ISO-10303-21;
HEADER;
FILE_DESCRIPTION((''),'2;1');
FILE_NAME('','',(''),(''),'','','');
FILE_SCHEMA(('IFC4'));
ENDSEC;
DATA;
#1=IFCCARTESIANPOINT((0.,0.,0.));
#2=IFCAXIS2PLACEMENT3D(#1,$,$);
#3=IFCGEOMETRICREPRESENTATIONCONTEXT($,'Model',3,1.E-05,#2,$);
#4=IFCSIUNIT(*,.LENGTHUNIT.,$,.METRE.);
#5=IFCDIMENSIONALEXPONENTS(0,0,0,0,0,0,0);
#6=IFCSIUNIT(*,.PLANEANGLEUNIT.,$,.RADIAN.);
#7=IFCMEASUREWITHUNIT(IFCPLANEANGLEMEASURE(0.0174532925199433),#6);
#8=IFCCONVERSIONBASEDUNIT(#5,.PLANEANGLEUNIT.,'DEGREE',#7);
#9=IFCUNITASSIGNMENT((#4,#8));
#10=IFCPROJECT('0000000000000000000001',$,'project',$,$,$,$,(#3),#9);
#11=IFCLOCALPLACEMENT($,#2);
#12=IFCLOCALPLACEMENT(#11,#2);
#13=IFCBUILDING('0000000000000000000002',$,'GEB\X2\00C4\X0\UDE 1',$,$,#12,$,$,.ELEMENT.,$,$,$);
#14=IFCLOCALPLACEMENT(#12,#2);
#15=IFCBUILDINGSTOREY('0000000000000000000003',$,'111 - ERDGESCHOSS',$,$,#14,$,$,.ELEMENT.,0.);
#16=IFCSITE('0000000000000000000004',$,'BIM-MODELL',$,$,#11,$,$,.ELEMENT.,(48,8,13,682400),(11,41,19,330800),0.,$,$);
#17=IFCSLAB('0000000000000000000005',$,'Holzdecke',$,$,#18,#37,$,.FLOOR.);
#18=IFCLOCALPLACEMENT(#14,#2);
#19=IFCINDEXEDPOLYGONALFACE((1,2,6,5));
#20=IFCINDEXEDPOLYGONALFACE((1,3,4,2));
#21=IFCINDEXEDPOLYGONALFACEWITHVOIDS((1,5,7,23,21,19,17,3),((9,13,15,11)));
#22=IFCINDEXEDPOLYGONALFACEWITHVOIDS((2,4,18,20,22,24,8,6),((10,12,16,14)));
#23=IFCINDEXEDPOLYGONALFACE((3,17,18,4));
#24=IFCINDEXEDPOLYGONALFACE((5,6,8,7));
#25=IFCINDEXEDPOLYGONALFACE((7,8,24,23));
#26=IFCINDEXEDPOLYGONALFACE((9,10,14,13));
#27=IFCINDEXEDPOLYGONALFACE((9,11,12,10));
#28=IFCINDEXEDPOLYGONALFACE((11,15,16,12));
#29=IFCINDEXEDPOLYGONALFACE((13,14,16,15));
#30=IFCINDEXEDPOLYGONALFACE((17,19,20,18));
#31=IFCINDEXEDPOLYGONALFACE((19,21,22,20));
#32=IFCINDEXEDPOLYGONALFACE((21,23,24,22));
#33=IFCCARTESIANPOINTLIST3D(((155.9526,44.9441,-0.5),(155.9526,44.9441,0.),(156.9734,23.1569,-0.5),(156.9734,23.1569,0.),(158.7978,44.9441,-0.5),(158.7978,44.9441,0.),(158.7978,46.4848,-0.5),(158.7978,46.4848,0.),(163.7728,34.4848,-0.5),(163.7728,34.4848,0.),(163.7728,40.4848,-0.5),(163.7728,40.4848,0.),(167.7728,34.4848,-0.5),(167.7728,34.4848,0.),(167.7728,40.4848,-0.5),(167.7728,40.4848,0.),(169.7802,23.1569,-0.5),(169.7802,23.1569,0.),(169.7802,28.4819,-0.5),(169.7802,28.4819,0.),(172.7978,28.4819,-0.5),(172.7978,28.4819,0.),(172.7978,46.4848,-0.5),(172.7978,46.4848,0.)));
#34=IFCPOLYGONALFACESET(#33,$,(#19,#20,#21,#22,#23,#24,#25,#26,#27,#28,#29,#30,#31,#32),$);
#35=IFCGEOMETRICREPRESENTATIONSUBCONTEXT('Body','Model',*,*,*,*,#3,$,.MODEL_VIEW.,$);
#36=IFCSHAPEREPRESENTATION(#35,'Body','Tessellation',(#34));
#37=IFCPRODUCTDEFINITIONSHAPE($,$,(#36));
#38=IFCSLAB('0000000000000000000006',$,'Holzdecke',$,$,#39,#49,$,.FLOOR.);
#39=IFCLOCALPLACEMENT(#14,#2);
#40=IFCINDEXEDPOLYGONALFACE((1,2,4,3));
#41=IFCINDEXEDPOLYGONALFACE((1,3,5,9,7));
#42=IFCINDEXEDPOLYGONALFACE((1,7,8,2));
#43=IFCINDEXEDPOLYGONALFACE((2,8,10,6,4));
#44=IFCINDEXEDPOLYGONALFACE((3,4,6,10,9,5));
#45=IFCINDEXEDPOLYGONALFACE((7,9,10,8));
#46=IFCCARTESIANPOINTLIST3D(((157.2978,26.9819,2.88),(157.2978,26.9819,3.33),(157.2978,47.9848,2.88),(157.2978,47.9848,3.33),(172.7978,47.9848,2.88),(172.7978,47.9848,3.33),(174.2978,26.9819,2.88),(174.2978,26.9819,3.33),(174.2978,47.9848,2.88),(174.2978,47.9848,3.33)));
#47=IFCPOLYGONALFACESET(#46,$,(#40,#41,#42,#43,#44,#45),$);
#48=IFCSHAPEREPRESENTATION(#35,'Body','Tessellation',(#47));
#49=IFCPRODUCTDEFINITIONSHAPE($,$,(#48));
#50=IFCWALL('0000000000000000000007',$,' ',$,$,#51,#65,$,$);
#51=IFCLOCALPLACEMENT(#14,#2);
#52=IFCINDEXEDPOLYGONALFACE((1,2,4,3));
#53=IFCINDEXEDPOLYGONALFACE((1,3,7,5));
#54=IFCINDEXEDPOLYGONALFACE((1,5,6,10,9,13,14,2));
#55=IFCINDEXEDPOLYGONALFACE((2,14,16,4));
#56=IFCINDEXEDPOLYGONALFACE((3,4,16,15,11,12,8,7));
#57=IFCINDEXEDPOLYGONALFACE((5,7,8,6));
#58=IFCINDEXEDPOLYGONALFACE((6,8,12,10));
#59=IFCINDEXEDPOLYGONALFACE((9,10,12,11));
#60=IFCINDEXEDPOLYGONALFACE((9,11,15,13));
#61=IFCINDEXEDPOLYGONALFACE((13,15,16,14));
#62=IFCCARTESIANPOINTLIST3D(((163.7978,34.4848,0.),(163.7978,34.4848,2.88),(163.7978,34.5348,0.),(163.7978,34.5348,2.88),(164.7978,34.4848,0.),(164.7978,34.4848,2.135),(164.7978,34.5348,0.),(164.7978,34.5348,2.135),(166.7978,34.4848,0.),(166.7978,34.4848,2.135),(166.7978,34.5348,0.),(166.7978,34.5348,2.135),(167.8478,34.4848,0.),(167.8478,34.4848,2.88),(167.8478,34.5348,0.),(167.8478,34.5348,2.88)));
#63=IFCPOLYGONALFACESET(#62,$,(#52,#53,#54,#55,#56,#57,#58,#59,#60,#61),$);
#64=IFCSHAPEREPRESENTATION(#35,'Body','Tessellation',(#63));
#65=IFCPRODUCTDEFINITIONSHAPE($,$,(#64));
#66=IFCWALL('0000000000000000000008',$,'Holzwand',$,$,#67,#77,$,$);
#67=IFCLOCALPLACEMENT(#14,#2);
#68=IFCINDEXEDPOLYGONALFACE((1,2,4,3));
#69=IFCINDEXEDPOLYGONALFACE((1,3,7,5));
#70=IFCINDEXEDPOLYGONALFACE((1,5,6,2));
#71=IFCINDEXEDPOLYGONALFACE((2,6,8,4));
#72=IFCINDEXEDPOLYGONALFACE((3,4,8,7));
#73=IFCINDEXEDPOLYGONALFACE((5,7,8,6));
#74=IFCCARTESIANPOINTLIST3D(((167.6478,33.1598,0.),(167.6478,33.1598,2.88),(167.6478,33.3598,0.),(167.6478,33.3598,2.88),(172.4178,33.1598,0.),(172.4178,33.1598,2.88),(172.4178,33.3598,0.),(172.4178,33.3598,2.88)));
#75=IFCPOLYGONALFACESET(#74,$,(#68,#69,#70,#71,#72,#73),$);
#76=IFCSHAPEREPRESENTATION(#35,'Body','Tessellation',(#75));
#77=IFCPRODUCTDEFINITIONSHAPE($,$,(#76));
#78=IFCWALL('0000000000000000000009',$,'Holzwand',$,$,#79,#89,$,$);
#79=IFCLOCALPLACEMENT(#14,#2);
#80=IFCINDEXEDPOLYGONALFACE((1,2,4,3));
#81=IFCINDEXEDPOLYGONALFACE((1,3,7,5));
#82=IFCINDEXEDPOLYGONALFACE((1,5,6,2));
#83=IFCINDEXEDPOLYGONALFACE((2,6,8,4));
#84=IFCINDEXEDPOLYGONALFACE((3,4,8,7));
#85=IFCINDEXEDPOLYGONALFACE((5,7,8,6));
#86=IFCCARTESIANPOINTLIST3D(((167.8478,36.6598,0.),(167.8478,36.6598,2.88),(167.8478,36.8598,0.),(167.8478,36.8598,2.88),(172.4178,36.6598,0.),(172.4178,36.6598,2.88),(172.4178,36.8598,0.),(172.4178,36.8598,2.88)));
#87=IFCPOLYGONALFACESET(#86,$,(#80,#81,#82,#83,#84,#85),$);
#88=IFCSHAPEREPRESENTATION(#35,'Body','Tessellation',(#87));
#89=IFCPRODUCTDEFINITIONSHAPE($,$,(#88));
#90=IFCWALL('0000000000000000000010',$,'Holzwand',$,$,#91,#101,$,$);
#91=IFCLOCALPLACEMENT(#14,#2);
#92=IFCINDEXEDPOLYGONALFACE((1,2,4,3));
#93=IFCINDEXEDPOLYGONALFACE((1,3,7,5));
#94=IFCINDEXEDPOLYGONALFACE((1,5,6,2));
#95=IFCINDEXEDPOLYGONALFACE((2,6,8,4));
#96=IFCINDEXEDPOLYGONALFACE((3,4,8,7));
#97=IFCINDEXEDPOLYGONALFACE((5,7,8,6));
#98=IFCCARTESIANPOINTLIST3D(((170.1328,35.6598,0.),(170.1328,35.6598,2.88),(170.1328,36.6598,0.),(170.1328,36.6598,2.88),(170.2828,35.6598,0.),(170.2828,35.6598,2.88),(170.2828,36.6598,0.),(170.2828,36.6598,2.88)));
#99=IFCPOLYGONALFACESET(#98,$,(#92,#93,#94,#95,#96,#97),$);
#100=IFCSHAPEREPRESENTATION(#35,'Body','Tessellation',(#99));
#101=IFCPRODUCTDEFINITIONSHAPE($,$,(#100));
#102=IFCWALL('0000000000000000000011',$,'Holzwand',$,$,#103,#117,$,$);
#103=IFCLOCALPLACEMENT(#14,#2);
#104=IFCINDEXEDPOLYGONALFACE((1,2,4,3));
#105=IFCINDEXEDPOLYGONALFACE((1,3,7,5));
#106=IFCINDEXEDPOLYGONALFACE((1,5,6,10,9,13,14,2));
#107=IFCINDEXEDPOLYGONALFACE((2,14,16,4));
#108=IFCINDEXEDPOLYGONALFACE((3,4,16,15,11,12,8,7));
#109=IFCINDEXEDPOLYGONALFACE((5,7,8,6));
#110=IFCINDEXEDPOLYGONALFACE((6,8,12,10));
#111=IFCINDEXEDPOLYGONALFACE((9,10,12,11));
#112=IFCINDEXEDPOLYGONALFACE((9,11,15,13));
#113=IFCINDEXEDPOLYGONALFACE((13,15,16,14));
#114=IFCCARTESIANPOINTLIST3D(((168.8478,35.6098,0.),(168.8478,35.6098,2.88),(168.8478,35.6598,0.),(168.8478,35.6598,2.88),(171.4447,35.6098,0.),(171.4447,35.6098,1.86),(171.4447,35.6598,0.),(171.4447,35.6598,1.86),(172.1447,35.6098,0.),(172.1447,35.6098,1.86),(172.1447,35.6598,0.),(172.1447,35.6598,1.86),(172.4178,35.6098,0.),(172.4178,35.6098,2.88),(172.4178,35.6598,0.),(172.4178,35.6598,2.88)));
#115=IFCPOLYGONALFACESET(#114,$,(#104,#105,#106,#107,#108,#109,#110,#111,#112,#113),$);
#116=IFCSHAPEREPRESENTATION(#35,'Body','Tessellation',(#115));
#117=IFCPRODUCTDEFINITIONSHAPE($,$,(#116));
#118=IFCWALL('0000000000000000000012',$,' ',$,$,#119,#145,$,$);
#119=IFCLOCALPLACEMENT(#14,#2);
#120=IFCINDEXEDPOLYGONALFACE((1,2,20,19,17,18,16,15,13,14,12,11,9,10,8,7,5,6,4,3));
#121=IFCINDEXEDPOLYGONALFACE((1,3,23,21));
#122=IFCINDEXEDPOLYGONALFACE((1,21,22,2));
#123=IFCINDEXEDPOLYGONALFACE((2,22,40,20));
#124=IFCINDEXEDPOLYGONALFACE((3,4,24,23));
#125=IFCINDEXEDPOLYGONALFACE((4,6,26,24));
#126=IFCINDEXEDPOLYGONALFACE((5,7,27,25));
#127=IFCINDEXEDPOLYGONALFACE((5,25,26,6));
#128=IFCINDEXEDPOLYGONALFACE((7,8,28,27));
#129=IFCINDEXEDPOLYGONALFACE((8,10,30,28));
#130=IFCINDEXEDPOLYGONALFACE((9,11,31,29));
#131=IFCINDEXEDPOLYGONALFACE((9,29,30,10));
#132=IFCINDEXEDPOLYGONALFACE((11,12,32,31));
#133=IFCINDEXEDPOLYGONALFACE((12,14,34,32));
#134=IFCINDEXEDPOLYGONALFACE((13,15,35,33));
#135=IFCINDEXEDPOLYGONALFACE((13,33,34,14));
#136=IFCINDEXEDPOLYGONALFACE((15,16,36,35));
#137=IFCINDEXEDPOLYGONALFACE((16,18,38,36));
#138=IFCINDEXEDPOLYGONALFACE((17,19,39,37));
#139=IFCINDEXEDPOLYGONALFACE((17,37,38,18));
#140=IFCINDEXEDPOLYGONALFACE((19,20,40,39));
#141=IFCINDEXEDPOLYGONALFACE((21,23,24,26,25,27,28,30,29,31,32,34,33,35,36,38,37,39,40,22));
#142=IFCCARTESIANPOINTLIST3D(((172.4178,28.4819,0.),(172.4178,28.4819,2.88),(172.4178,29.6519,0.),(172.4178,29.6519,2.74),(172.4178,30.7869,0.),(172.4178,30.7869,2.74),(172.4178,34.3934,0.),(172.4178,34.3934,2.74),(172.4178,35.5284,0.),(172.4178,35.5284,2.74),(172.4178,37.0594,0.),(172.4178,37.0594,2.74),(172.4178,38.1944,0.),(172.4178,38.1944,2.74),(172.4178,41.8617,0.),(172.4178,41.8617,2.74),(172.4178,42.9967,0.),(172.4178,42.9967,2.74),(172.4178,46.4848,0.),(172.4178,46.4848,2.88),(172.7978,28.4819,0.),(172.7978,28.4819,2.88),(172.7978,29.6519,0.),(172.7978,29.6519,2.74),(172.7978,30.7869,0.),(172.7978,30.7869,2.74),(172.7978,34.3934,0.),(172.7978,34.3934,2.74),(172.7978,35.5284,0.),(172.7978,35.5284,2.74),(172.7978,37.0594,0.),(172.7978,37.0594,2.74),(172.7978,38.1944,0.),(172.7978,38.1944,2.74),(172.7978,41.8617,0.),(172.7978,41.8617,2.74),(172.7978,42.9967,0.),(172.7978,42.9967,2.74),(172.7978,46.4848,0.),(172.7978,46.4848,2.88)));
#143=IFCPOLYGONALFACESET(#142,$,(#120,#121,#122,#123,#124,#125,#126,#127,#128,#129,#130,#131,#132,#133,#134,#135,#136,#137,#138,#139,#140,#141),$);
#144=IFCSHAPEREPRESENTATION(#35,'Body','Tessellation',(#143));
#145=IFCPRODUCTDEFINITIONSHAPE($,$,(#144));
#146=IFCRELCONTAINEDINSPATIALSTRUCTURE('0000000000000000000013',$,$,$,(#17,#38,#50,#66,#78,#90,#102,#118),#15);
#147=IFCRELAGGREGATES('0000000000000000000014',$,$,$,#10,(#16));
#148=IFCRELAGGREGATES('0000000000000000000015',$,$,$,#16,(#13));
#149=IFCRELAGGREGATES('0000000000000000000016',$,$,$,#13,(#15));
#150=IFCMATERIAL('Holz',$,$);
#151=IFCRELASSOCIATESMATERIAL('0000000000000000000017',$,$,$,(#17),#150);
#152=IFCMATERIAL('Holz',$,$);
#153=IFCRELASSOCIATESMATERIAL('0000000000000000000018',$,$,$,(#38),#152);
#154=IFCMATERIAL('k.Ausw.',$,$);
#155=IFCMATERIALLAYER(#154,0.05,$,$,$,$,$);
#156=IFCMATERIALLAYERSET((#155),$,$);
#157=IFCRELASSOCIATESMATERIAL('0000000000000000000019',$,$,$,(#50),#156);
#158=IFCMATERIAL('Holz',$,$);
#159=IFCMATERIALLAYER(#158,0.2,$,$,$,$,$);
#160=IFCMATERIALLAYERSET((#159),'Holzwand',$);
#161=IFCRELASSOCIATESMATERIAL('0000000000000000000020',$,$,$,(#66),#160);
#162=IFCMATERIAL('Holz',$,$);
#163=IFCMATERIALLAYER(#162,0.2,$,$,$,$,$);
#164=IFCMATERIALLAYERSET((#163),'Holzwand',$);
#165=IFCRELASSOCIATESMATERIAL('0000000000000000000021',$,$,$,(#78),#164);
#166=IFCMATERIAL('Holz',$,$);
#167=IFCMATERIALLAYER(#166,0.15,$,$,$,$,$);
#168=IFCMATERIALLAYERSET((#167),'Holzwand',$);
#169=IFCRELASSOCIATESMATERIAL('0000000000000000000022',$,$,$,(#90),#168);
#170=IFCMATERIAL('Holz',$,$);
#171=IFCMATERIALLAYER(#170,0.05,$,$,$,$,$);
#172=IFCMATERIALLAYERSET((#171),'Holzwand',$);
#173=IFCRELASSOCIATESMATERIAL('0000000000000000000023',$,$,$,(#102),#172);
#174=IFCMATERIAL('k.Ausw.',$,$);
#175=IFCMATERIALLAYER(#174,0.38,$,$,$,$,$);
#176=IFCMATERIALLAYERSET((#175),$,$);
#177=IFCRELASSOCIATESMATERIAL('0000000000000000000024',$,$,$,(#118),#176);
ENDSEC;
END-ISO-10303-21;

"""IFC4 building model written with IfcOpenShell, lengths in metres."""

from ifc_helpers import new_model, entity, si_unit, converted_unit, frame, frame_2d, origin, origin_with_axes, place, context, subcontext, project, spatial, polyline, rectangle, outline, extrude, material, layer, layer_set, layer_usage, element, save


model = new_model("IFC4")

# Units and contexts
model_context = context("Model", 3, precision=1e-05, world=origin())
body_context = subcontext(model_context, "Body", "Model", "MODEL_VIEW")
ifc_project = project(units=[si_unit("LENGTHUNIT", "METRE"), converted_unit("PLANEANGLEUNIT", "DEGREE", entity("IfcPlaneAngleMeasure", 0.0174532925199433), si_unit("PLANEANGLEUNIT", "RADIAN"), dimensions=[0, 0, 0, 0, 0, 0, 0])], contexts=[model_context])

# Site, building, storey
site_placement = place(None, origin())
site = spatial("IfcSite", under=ifc_project, at=site_placement, Name="BIM-MODELL", CompositionType="ELEMENT", RefLatitude=(48, 8, 13, 682400), RefLongitude=(11, 41, 19, 330800), RefElevation=0.0)
building_placement = place(site_placement, origin())
building = spatial("IfcBuilding", under=site, at=building_placement, Name="GEBÄUDE 1", CompositionType="ELEMENT")
storey_placement = place(building_placement, origin())
storey = spatial("IfcBuildingStorey", under=building, at=storey_placement, Name="111 - ERDGESCHOSS", CompositionType="ELEMENT", Elevation=0.0)

# Slabs
ifc_material_1 = material(Name="Holz")
slab_1_placement = place(storey_placement, frame((155.9526, 23.1569, -0.5)))
element("IfcSlab", 1, at=slab_1_placement, inside=storey, material=ifc_material_1, Name="Holzdecke", PredefinedType="FLOOR", context=body_context, shape_type="SweptSolid", body=[
    extrude(outline(polyline([(0.0, 21.7872), (1.0208, 0.0), (13.8276, 0.0), (13.8276, 5.3251), (16.8452, 5.3251), (16.8452, 23.3279), (2.8452, 23.3279), (2.8452, 21.7872), (0.0, 21.7872)]), holes=[polyline([(7.8202, 17.3279), (11.8202, 17.3279), (11.8202, 11.3279), (7.8202, 11.3279), (7.8202, 17.3279)])]), origin_with_axes(), (0.0, 0.0, 1.0), 0.5),
])
ifc_material_2 = material(Name="Holz")
slab_2_placement = place(storey_placement, frame((157.2978, 26.9819, 2.88)))
element("IfcSlab", 2, at=slab_2_placement, inside=storey, material=ifc_material_2, Name="Holzdecke", PredefinedType="FLOOR", context=body_context, shape_type="SweptSolid", body=[
    extrude(outline(polyline([(17.0, 0.0), (17.0, 21.0029), (15.5, 21.0029), (0.0, 21.0029), (0.0, 0.0), (17.0, 0.0)])), origin_with_axes(), (0.0, 0.0, 1.0), 0.45),
])

# Wall, opening
ifc_material_3 = material(Name="k.Ausw.")
ifc_layer_1 = layer(ifc_material_3, 0.05)
ifc_layer_set_1 = layer_set([ifc_layer_1])
ifc_layer_usage_1 = layer_usage(ifc_layer_set_1, "AXIS2", "POSITIVE", 0.0)
wall_1_placement = place(storey_placement, frame((163.7978, 34.4848, 0.0), z_axis=(0.0, 0.0, 1.0), x_axis=(1.0, 0.0, 0.0)))
wall_1 = element("IfcWall", 3, at=wall_1_placement, inside=storey, material=ifc_layer_usage_1, Name=" ", context=body_context, shape_type="SweptSolid", body=[
    extrude(rectangle(XDim=4.05, YDim=0.05, at=frame_2d((2.025, 0.025), x_axis=(1.0, 0.0))), origin_with_axes(), (0.0, 0.0, 1.0), 2.88),
])
opening_1_placement = place(wall_1_placement, frame((1.0, 0.0, 0.0), z_axis=(0.0, 1.0, 0.0), x_axis=(0.0, 0.0, 1.0)))
element("IfcOpeningElement", 4, at=opening_1_placement, cuts=wall_1, ObjectType="Opening", context=body_context, shape_type="SweptSolid", body=[
    extrude(outline(polyline([(0.0, 2.0), (2.135, 2.0), (2.135, 0.0), (0.0, 0.0), (0.0, 2.0)])), origin_with_axes(), (0.0, 0.0, 1.0), 0.05),
])

# Walls
ifc_material_4 = material(Name="Holz")
ifc_layer_2 = layer(ifc_material_4, 0.2)
ifc_layer_set_2 = layer_set([ifc_layer_2], Name="Holzwand")
ifc_layer_usage_2 = layer_usage(ifc_layer_set_2, "AXIS2", "POSITIVE", 0.0)
wall_2_placement = place(storey_placement, frame((167.6478, 33.1598, 0.0)))
element("IfcWall", 5, at=wall_2_placement, inside=storey, material=ifc_layer_usage_2, Name="Holzwand", context=body_context, shape_type="SweptSolid", body=[
    extrude(rectangle(XDim=4.77, YDim=0.2, at=frame_2d((2.385, 0.1), x_axis=(1.0, 0.0))), origin_with_axes(), (0.0, 0.0, 1.0), 2.88),
])
ifc_material_5 = material(Name="Holz")
ifc_layer_3 = layer(ifc_material_5, 0.2)
ifc_layer_set_3 = layer_set([ifc_layer_3], Name="Holzwand")
ifc_layer_usage_3 = layer_usage(ifc_layer_set_3, "AXIS2", "POSITIVE", 0.0)
wall_3_placement = place(storey_placement, frame((167.8478, 36.6598, 0.0)))
element("IfcWall", 6, at=wall_3_placement, inside=storey, material=ifc_layer_usage_3, Name="Holzwand", context=body_context, shape_type="SweptSolid", body=[
    extrude(rectangle(XDim=4.57, YDim=0.2, at=frame_2d((2.285, 0.1), x_axis=(1.0, 0.0))), origin_with_axes(), (0.0, 0.0, 1.0), 2.88),
])
ifc_material_6 = material(Name="Holz")
ifc_layer_4 = layer(ifc_material_6, 0.15)
ifc_layer_set_4 = layer_set([ifc_layer_4], Name="Holzwand")
ifc_layer_usage_4 = layer_usage(ifc_layer_set_4, "AXIS2", "POSITIVE", -0.075)
wall_4_placement = place(storey_placement, frame((170.1328, 36.6598, 0.0), z_axis=(0.0, 0.0, 1.0), x_axis=(0.0, -1.0, 0.0)))
element("IfcWall", 7, at=wall_4_placement, inside=storey, material=ifc_layer_usage_4, Name="Holzwand", context=body_context, shape_type="SweptSolid", body=[
    extrude(rectangle(XDim=1.0, YDim=0.15, at=frame_2d((0.5, 0.075), x_axis=(1.0, 0.0))), origin_with_axes(), (0.0, 0.0, 1.0), 2.88),
])

# Wall, opening
ifc_material_7 = material(Name="Holz")
ifc_layer_5 = layer(ifc_material_7, 0.05)
ifc_layer_set_5 = layer_set([ifc_layer_5], Name="Holzwand")
ifc_layer_usage_5 = layer_usage(ifc_layer_set_5, "AXIS2", "POSITIVE", 0.0)
wall_5_placement = place(storey_placement, frame((172.4178, 35.6598, 0.0), z_axis=(0.0, 0.0, 1.0), x_axis=(-1.0, 0.0, 0.0)))
wall_5 = element("IfcWall", 8, at=wall_5_placement, inside=storey, material=ifc_layer_usage_5, Name="Holzwand", context=body_context, shape_type="SweptSolid", body=[
    extrude(rectangle(XDim=3.57, YDim=0.05, at=frame_2d((1.785, 0.025), x_axis=(1.0, 0.0))), origin_with_axes(), (0.0, 0.0, 1.0), 2.88),
])
opening_2_placement = place(wall_5_placement, frame((0.273, 0.0, -0.15), z_axis=(0.0, 1.0, 0.0), x_axis=(0.0, 0.0, 1.0)))
element("IfcOpeningElement", 9, at=opening_2_placement, cuts=wall_5, ObjectType="Opening", context=body_context, shape_type="SweptSolid", body=[
    extrude(outline(polyline([(0.0, 0.7), (2.01, 0.7), (2.01, 0.0), (0.0, 0.0), (0.0, 0.7)])), origin_with_axes(), (0.0, 0.0, 1.0), 0.05),
])

# Wall, openings
ifc_material_8 = material(Name="k.Ausw.")
ifc_layer_6 = layer(ifc_material_8, 0.38)
ifc_layer_set_6 = layer_set([ifc_layer_6])
ifc_layer_usage_6 = layer_usage(ifc_layer_set_6, "AXIS2", "POSITIVE", 0.0)
wall_6_placement = place(storey_placement, frame((172.7978, 28.4819, 0.0), z_axis=(0.0, 0.0, 1.0), x_axis=(0.0, 1.0, 0.0)))
wall_6 = element("IfcWall", 10, at=wall_6_placement, inside=storey, material=ifc_layer_usage_6, Name=" ", context=body_context, shape_type="SweptSolid", body=[
    extrude(rectangle(XDim=18.0029, YDim=0.38, at=frame_2d((9.0014, 0.19), x_axis=(1.0, 0.0))), origin_with_axes(), (0.0, 0.0, 1.0), 2.88),
])
opening_3_placement = place(wall_6_placement, frame((1.17, 0.0, 0.0), z_axis=(0.0, 1.0, 0.0), x_axis=(0.0, 0.0, 1.0)))
element("IfcOpeningElement", 11, at=opening_3_placement, cuts=wall_6, ObjectType="Opening", context=body_context, shape_type="SweptSolid", body=[
    extrude(outline(polyline([(0.0, 1.135), (2.74, 1.135), (2.74, 0.0), (0.0, 0.0), (0.0, 1.135)])), origin_with_axes(), (0.0, 0.0, 1.0), 0.38),
])
opening_4_placement = place(wall_6_placement, frame((5.9114, 0.0, 0.0), z_axis=(0.0, 1.0, 0.0), x_axis=(0.0, 0.0, 1.0)))
element("IfcOpeningElement", 12, at=opening_4_placement, cuts=wall_6, ObjectType="Opening", context=body_context, shape_type="SweptSolid", body=[
    extrude(outline(polyline([(0.0, 1.135), (2.74, 1.135), (2.74, 0.0), (0.0, 0.0), (0.0, 1.135)])), origin_with_axes(), (0.0, 0.0, 1.0), 0.38),
])
opening_5_placement = place(wall_6_placement, frame((8.5775, 0.0, 0.0), z_axis=(0.0, 1.0, 0.0), x_axis=(0.0, 0.0, 1.0)))
element("IfcOpeningElement", 13, at=opening_5_placement, cuts=wall_6, ObjectType="Opening", context=body_context, shape_type="SweptSolid", body=[
    extrude(outline(polyline([(0.0, 1.135), (2.74, 1.135), (2.74, 0.0), (0.0, 0.0), (0.0, 1.135)])), origin_with_axes(), (0.0, 0.0, 1.0), 0.38),
])
opening_6_placement = place(wall_6_placement, frame((13.3798, 0.0, 0.0), z_axis=(0.0, 1.0, 0.0), x_axis=(0.0, 0.0, 1.0)))
element("IfcOpeningElement", 14, at=opening_6_placement, cuts=wall_6, ObjectType="Opening", context=body_context, shape_type="SweptSolid", body=[
    extrude(outline(polyline([(0.0, 1.135), (2.74, 1.135), (2.74, 0.0), (0.0, 0.0), (0.0, 1.135)])), origin_with_axes(), (0.0, 0.0, 1.0), 0.38),
])

save(model, "model.ifc")
